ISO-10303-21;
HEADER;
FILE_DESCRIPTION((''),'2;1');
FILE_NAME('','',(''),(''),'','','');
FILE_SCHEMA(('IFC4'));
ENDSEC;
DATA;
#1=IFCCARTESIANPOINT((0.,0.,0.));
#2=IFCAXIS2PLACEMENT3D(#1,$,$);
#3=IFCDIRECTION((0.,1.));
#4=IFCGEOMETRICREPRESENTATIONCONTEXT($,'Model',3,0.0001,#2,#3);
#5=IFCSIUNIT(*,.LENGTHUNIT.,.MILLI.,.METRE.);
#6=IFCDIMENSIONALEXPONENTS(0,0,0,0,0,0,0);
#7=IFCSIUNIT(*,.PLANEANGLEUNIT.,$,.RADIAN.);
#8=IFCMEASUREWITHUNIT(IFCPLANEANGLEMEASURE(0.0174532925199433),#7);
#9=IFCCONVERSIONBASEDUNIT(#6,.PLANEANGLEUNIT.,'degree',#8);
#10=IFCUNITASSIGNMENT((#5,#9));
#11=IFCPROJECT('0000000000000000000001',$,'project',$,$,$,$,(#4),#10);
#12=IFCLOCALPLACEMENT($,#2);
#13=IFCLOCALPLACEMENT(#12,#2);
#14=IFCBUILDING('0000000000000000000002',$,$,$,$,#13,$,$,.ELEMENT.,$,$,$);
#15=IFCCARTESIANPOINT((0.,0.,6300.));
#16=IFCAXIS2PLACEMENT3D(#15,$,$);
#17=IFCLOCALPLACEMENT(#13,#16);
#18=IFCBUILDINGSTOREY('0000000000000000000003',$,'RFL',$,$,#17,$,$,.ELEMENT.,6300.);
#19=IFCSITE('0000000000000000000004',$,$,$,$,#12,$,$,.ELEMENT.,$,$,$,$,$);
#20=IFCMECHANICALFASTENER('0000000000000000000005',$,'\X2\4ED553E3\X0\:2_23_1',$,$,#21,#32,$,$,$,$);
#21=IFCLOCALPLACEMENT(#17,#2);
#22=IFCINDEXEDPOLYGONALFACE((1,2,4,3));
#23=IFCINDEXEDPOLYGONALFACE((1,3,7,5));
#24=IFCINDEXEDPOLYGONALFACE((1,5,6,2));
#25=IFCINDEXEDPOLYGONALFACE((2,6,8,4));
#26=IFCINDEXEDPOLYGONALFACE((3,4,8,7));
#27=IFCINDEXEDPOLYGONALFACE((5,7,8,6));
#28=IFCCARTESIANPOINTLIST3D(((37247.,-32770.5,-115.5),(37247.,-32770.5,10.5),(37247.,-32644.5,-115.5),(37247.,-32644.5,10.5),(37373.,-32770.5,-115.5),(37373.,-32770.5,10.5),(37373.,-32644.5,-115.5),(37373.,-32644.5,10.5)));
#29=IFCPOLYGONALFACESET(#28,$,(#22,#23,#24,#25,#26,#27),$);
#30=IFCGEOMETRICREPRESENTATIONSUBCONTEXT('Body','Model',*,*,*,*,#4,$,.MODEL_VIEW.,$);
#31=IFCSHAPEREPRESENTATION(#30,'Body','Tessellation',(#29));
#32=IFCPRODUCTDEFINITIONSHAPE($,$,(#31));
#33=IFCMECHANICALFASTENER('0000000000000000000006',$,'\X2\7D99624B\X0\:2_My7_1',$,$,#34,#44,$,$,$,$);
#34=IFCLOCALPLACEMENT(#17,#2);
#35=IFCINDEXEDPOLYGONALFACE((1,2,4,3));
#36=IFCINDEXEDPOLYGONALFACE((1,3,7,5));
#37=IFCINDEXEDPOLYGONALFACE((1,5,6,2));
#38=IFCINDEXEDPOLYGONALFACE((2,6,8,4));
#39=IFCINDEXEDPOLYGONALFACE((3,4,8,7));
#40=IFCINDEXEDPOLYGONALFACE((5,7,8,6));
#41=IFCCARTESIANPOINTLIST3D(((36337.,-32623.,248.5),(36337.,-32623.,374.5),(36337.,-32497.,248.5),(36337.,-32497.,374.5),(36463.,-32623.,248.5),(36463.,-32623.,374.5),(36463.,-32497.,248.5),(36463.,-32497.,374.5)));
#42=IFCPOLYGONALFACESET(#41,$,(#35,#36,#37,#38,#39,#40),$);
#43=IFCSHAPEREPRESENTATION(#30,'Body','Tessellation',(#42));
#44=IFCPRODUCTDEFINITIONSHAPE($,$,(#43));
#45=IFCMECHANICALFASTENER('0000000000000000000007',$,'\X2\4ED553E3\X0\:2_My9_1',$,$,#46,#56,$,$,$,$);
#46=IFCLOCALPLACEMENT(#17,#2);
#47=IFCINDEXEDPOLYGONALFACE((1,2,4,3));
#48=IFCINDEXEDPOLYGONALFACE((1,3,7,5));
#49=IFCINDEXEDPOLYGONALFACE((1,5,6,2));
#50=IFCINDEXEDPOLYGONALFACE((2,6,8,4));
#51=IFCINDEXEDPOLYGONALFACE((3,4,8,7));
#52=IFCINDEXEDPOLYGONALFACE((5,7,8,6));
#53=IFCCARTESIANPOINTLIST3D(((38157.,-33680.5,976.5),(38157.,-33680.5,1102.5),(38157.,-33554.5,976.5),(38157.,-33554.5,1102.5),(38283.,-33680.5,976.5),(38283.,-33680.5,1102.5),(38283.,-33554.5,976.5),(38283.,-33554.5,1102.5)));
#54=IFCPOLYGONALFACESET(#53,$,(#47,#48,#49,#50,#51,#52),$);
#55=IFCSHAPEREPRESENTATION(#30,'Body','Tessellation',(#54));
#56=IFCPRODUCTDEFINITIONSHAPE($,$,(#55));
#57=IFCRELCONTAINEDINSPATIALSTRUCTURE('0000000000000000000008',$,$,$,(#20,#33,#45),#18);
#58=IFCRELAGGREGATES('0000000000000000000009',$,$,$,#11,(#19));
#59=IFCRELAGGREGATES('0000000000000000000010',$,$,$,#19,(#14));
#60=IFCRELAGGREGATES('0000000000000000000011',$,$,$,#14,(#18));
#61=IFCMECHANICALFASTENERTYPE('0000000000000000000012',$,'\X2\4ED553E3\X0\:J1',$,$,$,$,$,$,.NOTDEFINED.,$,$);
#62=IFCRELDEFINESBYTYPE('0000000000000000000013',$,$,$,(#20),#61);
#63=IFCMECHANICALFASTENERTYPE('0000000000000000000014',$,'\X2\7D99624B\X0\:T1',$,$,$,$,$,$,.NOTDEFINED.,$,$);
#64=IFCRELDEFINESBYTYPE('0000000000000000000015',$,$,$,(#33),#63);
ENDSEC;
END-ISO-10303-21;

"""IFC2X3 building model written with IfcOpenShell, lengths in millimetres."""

from ifc_helpers import new_model, entity, si_unit, converted_unit, direction, frame, origin, origin_with_axes, origin_2d, place, context, subcontext, project, spatial, rectangle, extrude, type_object, element, save


model = new_model("IFC2X3")

# Units and contexts
model_context = context("Model", 3, precision=0.0001, world=origin(), true_north=direction((0.0, 1.0)))
body_context = subcontext(model_context, "Body", "Model", "MODEL_VIEW")
ifc_project = project(units=[si_unit("LENGTHUNIT", "METRE", prefix="MILLI"), converted_unit("PLANEANGLEUNIT", "degree", entity("IfcPlaneAngleMeasure", 0.0174532925199433), si_unit("PLANEANGLEUNIT", "RADIAN"), dimensions=[0, 0, 0, 0, 0, 0, 0])], contexts=[model_context])

# Site, building, storey
site_placement = place(None, origin())
site = spatial("IfcSite", under=ifc_project, at=site_placement, CompositionType="ELEMENT")
building_placement = place(site_placement, origin())
building = spatial("IfcBuilding", under=site, at=building_placement, CompositionType="ELEMENT")
storey_placement = place(building_placement, frame((0.0, 0.0, 6300.0)))
storey = spatial("IfcBuildingStorey", under=building, at=storey_placement, Name="RFL", CompositionType="ELEMENT", Elevation=6300.0)

# Mechanical fasteners
mechanical_fastener_type_1 = type_object("IfcMechanicalFastenerType", Name="仕口:J1")
mechanical_fastener_1_placement = place(storey_placement, frame((37310.0, -32707.5, -115.5)))
element("IfcMechanicalFastener", 1, at=mechanical_fastener_1_placement, inside=storey, type_object=mechanical_fastener_type_1, Name="仕口:2_23_1", context=body_context, shape_type="SweptSolid", body=[
    extrude(rectangle(XDim=126.0, YDim=126.0, at=origin_2d()), origin_with_axes(), (0.0, 0.0, 1.0), 126.0),
])
mechanical_fastener_type_2 = type_object("IfcMechanicalFastenerType", Name="継手:T1")
mechanical_fastener_2_placement = place(storey_placement, frame((36400.0, -32560.0, 248.5)))
element("IfcMechanicalFastener", 2, at=mechanical_fastener_2_placement, inside=storey, type_object=mechanical_fastener_type_2, Name="継手:2_My7_1", context=body_context, shape_type="SweptSolid", body=[
    extrude(rectangle(XDim=126.0, YDim=126.0, at=origin_2d()), origin_with_axes(), (0.0, 0.0, 1.0), 126.0),
])
mechanical_fastener_3_placement = place(storey_placement, frame((38220.0, -33617.5, 976.5)))
element("IfcMechanicalFastener", 3, at=mechanical_fastener_3_placement, inside=storey, Name="仕口:2_My9_1", context=body_context, shape_type="SweptSolid", body=[
    extrude(rectangle(XDim=126.0, YDim=126.0, at=origin_2d()), origin_with_axes(), (0.0, 0.0, 1.0), 126.0),
])

save(model, "model.ifc")
